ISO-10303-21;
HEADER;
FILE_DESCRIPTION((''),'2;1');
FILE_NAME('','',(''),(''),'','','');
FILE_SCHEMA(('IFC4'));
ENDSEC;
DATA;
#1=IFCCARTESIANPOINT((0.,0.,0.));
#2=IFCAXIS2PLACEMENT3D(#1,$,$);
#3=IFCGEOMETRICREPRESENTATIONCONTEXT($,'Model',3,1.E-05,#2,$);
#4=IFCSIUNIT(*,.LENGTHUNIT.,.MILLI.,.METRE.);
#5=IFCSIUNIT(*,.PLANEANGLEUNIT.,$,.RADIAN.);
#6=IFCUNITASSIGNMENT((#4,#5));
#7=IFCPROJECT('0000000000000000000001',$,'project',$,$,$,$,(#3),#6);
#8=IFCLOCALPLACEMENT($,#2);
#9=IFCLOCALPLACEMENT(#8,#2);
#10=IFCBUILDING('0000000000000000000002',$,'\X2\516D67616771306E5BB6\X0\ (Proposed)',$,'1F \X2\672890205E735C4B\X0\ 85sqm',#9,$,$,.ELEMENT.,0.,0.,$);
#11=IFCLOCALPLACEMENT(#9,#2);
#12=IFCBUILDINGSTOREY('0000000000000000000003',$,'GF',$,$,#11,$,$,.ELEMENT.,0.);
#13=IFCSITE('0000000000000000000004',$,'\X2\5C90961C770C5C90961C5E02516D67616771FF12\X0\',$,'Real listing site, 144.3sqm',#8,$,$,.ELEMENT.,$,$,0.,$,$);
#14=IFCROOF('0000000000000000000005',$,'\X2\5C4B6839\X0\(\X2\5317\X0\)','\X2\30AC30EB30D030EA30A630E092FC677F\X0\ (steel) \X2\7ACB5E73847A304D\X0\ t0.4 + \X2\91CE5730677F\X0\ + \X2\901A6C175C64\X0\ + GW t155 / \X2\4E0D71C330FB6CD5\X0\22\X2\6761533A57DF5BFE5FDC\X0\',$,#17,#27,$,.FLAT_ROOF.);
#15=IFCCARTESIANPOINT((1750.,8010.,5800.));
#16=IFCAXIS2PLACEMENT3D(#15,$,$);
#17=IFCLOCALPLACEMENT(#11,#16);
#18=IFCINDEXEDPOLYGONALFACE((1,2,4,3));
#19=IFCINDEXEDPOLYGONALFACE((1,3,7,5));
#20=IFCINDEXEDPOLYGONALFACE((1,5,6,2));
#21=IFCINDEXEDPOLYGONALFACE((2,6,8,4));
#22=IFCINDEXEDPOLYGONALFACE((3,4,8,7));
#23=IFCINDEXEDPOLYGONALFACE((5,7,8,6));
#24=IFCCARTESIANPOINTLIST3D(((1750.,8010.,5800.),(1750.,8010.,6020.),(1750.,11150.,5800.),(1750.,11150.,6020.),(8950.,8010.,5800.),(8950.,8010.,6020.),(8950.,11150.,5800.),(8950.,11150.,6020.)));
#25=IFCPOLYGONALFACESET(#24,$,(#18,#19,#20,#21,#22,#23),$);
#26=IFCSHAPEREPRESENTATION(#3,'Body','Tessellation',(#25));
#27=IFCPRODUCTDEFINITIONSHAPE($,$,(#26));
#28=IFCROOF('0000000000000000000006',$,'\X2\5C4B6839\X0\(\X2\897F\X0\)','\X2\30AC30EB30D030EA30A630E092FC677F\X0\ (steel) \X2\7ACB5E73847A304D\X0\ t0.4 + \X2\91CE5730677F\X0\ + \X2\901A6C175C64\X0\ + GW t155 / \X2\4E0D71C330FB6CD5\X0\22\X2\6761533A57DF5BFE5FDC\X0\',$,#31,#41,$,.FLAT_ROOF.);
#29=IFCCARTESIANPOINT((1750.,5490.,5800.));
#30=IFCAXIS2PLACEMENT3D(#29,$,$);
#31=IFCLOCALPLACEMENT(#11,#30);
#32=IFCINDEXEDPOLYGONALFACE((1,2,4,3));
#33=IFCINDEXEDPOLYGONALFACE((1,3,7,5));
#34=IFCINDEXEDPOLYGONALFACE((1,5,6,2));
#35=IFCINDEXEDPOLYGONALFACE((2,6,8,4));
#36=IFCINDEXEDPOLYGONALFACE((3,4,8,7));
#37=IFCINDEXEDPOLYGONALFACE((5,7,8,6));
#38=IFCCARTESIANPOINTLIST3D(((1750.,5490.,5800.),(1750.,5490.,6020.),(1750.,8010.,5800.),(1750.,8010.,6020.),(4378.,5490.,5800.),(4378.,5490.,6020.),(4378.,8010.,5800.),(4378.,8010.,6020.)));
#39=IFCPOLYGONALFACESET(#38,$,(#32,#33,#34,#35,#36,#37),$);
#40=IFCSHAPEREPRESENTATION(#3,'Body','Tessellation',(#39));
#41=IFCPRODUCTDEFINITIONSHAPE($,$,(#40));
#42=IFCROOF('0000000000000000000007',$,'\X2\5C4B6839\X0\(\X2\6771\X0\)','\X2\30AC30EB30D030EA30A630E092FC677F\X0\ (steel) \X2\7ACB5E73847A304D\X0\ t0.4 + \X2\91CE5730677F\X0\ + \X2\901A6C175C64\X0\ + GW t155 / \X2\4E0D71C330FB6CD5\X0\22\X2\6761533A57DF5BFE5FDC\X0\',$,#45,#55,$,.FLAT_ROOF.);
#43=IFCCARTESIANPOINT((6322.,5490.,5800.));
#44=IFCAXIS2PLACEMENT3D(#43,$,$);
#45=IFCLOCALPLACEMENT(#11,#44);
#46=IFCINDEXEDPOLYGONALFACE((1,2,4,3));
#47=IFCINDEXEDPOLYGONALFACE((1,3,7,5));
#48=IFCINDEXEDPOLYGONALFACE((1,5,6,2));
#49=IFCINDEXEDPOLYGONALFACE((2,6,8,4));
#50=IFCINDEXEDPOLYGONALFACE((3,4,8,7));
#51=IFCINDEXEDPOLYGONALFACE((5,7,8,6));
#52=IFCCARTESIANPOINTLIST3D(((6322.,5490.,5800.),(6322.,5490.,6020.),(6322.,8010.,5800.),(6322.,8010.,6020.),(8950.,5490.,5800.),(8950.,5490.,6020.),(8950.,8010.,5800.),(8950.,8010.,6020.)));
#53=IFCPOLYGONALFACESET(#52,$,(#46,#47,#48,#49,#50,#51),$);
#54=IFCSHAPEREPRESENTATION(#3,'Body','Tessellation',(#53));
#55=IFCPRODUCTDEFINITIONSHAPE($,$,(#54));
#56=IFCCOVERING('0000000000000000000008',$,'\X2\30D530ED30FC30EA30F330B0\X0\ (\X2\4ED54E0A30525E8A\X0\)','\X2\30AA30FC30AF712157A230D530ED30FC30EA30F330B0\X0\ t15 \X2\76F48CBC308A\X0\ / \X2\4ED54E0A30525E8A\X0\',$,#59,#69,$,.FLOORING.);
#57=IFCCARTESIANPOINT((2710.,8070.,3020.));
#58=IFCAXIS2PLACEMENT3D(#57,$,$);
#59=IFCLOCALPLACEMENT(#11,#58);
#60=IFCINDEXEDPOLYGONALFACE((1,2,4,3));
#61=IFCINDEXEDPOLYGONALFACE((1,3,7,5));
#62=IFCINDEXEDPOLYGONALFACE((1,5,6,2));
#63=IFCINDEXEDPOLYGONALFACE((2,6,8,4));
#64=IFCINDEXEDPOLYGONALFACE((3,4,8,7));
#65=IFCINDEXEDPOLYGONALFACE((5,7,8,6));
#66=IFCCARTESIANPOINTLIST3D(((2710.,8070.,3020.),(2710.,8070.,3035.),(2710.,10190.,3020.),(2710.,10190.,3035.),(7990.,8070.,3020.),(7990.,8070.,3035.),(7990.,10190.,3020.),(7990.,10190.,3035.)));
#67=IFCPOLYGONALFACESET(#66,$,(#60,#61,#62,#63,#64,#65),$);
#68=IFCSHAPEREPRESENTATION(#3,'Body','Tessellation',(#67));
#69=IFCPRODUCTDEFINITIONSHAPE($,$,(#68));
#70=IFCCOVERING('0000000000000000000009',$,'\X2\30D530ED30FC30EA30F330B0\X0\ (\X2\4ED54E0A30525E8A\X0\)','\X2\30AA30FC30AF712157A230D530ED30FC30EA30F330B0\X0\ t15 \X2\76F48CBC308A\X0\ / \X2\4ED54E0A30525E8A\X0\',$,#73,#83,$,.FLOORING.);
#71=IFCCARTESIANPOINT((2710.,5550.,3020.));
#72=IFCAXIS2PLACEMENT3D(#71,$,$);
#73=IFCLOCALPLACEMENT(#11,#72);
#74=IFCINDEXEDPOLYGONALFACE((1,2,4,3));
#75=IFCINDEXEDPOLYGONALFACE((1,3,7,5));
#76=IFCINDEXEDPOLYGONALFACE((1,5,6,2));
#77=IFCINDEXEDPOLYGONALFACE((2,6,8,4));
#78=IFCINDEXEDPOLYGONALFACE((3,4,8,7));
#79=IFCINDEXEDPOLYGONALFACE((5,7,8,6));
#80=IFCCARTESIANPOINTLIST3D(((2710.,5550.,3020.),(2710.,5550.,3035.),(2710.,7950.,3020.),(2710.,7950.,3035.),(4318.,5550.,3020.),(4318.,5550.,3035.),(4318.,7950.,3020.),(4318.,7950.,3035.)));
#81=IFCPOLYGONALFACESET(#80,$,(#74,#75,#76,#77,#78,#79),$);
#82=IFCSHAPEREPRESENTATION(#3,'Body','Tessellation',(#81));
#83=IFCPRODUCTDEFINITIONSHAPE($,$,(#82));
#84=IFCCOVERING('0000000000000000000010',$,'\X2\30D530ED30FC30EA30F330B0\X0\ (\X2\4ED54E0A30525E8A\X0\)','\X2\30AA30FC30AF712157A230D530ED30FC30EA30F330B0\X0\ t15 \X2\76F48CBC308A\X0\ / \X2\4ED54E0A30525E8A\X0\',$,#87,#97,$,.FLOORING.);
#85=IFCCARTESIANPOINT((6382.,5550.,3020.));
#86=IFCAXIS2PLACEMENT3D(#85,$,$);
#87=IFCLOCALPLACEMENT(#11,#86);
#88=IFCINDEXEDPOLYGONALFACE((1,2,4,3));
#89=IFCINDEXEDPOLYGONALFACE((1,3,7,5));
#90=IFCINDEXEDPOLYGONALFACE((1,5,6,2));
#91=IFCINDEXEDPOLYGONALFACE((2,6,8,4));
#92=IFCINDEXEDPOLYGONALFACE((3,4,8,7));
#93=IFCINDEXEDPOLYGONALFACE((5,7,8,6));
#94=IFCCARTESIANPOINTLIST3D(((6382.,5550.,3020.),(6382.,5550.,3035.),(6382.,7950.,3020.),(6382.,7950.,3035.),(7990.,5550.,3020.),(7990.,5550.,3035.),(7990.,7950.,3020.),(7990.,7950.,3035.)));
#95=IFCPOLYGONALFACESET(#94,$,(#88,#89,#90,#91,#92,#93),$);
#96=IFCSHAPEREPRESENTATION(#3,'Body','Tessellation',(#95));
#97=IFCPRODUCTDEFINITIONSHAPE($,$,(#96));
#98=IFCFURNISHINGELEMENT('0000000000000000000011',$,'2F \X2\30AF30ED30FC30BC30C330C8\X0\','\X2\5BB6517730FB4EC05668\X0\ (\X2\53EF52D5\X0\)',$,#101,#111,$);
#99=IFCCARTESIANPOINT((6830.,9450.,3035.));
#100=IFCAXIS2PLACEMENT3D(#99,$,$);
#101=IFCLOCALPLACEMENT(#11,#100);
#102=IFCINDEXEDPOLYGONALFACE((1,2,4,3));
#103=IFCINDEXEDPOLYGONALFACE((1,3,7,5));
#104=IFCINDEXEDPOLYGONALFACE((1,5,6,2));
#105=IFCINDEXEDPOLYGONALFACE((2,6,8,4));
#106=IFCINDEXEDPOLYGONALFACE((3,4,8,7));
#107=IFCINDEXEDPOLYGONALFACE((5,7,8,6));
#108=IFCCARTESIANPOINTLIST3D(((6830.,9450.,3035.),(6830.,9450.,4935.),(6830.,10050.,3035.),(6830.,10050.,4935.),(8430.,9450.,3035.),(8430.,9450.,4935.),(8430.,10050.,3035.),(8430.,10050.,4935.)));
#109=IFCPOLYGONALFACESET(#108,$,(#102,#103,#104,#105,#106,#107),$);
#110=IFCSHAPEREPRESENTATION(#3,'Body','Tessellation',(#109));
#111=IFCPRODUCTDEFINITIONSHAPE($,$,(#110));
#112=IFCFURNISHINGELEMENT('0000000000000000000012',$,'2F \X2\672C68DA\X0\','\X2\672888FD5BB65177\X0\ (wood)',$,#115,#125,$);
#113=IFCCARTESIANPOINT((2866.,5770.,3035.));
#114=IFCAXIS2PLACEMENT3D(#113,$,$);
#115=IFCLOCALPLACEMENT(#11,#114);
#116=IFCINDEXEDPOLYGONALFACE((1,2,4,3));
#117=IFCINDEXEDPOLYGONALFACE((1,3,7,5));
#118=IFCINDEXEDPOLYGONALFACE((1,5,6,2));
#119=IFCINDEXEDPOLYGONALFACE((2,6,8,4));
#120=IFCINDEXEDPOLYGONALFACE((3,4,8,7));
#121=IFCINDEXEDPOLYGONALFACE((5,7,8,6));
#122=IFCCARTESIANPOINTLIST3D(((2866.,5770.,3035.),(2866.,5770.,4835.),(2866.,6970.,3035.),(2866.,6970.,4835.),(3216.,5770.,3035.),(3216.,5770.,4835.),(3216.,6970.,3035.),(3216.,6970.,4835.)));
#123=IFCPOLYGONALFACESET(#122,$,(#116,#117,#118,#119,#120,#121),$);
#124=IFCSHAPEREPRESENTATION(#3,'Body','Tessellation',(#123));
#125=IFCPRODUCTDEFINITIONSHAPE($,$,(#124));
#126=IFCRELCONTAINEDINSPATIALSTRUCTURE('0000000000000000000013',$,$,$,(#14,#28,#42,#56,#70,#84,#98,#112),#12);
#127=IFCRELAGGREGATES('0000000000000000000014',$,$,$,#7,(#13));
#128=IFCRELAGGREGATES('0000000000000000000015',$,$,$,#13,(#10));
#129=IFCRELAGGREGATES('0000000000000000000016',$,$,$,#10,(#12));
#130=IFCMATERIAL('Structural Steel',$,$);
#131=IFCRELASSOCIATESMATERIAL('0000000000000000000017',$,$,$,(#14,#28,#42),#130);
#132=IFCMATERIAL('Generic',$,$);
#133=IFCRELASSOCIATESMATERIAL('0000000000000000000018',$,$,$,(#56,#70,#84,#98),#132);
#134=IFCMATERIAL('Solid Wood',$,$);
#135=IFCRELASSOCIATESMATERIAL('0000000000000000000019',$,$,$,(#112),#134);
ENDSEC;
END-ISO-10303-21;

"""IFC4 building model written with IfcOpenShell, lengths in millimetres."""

from ifc_helpers import new_model, si_unit, frame, frame_2d, origin, place, context, project, spatial, rectangle, extrude, material, element, save


model = new_model("IFC4")

# Units and contexts
model_context = context("Model", 3, precision=1e-05, world=origin())
ifc_project = project(units=[si_unit("LENGTHUNIT", "METRE", prefix="MILLI"), si_unit("PLANEANGLEUNIT", "RADIAN")], contexts=[model_context])

# Site, building, storey
site_placement = place(None, origin())
site = spatial("IfcSite", under=ifc_project, at=site_placement, Name="岐阜県岐阜市六条東２", ObjectType="Real listing site, 144.3sqm", CompositionType="ELEMENT", RefElevation=0.0)
building_placement = place(site_placement, origin())
building = spatial("IfcBuilding", under=site, at=building_placement, Name="六条東の家 (Proposed)", ObjectType="1F 木造平屋 85sqm", CompositionType="ELEMENT", ElevationOfRefHeight=0.0, ElevationOfTerrain=0.0)
storey_placement = place(building_placement, origin())
storey = spatial("IfcBuildingStorey", under=building, at=storey_placement, Name="GF", CompositionType="ELEMENT", Elevation=0.0)

# Shared definitions
ifc_material_1 = material(Name="Solid Wood")

# Shared definitions
ifc_material_2 = material(Name="Generic")

# Roofs
ifc_material_3 = material(Name="Structural Steel")
for number, where, name in (
    (1, (1750.0, 8010.0, 5800.0), "屋根(北)"),
):
    element("IfcRoof", number, at=place(storey_placement, frame(where)), inside=storey, material=ifc_material_3, Name=name, Description="ガルバリウム鋼板 (steel) 立平葺き t0.4 + 野地板 + 通気層 + GW t155 / 不燃・法22条区域対応", PredefinedType="FLAT_ROOF", context=model_context, shape_type="SweptSolid", body=[
        extrude(rectangle(XDim=7200.0, YDim=3140.0, at=frame_2d((3600.0, 1570.0))), frame((1750.0, 8010.0, 5800.0)), (0.0, 0.0, 1.0), 220.0),
    ])
roof_1_placement = place(storey_placement, frame((1750.0, 5490.0, 5800.0)))
element("IfcRoof", 2, at=roof_1_placement, inside=storey, material=ifc_material_3, Name="屋根(西)", Description="ガルバリウム鋼板 (steel) 立平葺き t0.4 + 野地板 + 通気層 + GW t155 / 不燃・法22条区域対応", PredefinedType="FLAT_ROOF", context=model_context, shape_type="SweptSolid", body=[
    extrude(rectangle(XDim=2628.0, YDim=2520.0, at=frame_2d((1314.0, 1260.0))), frame((1750.0, 5490.0, 5800.0)), (0.0, 0.0, 1.0), 220.0),
])
roof_2_placement = place(storey_placement, frame((6322.0, 5490.0, 5800.0)))
element("IfcRoof", 3, at=roof_2_placement, inside=storey, material=ifc_material_3, Name="屋根(東)", Description="ガルバリウム鋼板 (steel) 立平葺き t0.4 + 野地板 + 通気層 + GW t155 / 不燃・法22条区域対応", PredefinedType="FLAT_ROOF", context=model_context, shape_type="SweptSolid", body=[
    extrude(rectangle(XDim=2628.0, YDim=2520.0, at=frame_2d((1314.0, 1260.0))), frame((6322.0, 5490.0, 5800.0)), (0.0, 0.0, 1.0), 220.0),
])

# Coverings
covering_1_placement = place(storey_placement, frame((2710.0, 8070.0, 3020.0)))
element("IfcCovering", 4, at=covering_1_placement, inside=storey, material=ifc_material_2, Name="フローリング (仕上げ床)", Description="オーク無垢フローリング t15 直貼り / 仕上げ床", PredefinedType="FLOORING", context=model_context, shape_type="SweptSolid", body=[
    extrude(rectangle(XDim=5280.0, YDim=2120.0, at=frame_2d((2640.0, 1060.0))), frame((2710.0, 8070.0, 3020.0)), (0.0, 0.0, 1.0), 15.0),
])
covering_2_placement = place(storey_placement, frame((2710.0, 5550.0, 3020.0)))
element("IfcCovering", 5, at=covering_2_placement, inside=storey, material=ifc_material_2, Name="フローリング (仕上げ床)", Description="オーク無垢フローリング t15 直貼り / 仕上げ床", PredefinedType="FLOORING", context=model_context, shape_type="SweptSolid", body=[
    extrude(rectangle(XDim=1608.0, YDim=2400.0, at=frame_2d((804.0, 1200.0))), frame((2710.0, 5550.0, 3020.0)), (0.0, 0.0, 1.0), 15.0),
])
covering_3_placement = place(storey_placement, frame((6382.0, 5550.0, 3020.0)))
element("IfcCovering", 6, at=covering_3_placement, inside=storey, material=ifc_material_2, Name="フローリング (仕上げ床)", Description="オーク無垢フローリング t15 直貼り / 仕上げ床", PredefinedType="FLOORING", context=model_context, shape_type="SweptSolid", body=[
    extrude(rectangle(XDim=1608.0, YDim=2400.0, at=frame_2d((804.0, 1200.0))), frame((6382.0, 5550.0, 3020.0)), (0.0, 0.0, 1.0), 15.0),
])

# Furnishing elements
furnishing_1_placement = place(storey_placement, frame((6830.0, 9450.0, 3035.0)))
element("IfcFurnishingElement", 7, at=furnishing_1_placement, inside=storey, material=ifc_material_2, Name="2F クローゼット", Description="家具・什器 (可動)", context=model_context, shape_type="SweptSolid", body=[
    extrude(rectangle(XDim=1600.0, YDim=600.0, at=frame_2d((800.0, 300.0))), frame((6830.0, 9450.0, 3035.0)), (0.0, 0.0, 1.0), 1900.0),
])
furnishing_2_placement = place(storey_placement, frame((2866.0, 5770.0, 3035.0)))
element("IfcFurnishingElement", 8, at=furnishing_2_placement, inside=storey, material=ifc_material_1, Name="2F 本棚", Description="木製家具 (wood)", context=model_context, shape_type="SweptSolid", body=[
    extrude(rectangle(XDim=350.0, YDim=1200.0, at=frame_2d((175.0, 600.0))), frame((2866.0, 5770.0, 3035.0)), (0.0, 0.0, 1.0), 1800.0),
])

save(model, "model.ifc")
